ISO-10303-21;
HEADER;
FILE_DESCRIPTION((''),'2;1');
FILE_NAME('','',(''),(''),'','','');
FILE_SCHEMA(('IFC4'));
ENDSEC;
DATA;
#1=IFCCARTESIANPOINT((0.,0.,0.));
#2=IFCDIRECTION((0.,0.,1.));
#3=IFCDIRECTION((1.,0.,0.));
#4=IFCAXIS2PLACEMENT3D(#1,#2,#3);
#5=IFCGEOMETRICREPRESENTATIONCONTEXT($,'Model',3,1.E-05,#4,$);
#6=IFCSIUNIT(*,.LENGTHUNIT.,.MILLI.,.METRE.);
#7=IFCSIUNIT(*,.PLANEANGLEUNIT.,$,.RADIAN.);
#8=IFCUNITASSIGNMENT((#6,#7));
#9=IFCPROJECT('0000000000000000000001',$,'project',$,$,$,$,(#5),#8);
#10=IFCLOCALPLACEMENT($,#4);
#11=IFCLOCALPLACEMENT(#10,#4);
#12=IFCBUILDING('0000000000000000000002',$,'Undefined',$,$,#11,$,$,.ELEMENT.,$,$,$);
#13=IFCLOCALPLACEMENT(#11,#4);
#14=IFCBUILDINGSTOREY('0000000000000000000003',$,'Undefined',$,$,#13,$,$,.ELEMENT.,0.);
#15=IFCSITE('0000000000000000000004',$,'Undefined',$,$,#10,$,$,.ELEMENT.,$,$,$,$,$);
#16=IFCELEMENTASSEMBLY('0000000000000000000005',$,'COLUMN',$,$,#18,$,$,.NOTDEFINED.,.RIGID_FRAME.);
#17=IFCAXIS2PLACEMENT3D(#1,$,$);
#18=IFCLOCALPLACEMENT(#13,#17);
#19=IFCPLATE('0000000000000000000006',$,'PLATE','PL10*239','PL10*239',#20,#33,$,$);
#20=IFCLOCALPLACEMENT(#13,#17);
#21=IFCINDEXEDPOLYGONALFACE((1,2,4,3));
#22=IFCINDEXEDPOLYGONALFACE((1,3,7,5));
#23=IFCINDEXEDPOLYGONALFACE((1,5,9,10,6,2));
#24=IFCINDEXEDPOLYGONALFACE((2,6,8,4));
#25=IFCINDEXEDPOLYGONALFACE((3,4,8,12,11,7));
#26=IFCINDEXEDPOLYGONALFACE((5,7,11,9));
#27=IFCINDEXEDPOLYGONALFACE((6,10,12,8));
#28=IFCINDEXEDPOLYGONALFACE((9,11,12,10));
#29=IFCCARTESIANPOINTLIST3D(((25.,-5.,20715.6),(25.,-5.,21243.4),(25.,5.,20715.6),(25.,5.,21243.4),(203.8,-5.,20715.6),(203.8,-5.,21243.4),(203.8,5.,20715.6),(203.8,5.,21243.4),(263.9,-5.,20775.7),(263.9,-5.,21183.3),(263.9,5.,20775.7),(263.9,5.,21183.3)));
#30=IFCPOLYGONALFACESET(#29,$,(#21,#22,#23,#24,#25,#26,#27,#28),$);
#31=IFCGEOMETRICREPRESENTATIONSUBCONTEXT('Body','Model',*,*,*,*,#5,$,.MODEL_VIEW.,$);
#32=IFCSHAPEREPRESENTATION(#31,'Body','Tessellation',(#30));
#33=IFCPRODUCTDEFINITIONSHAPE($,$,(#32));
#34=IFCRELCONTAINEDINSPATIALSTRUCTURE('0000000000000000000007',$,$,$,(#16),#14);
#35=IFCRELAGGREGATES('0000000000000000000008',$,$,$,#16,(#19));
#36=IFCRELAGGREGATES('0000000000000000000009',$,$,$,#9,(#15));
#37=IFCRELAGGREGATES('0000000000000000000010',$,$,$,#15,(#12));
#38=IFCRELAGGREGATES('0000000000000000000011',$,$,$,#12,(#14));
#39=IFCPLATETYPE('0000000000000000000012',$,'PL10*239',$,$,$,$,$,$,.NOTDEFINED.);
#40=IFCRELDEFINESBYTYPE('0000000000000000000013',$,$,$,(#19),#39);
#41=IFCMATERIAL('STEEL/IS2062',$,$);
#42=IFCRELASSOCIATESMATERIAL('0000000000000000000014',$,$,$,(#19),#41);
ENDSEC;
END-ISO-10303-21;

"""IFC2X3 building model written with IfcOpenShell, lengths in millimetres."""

from ifc_helpers import new_model, si_unit, frame, origin_with_axes, place, context, subcontext, project, spatial, polyline, outline, extrude, material, type_object, element, aggregate, save


model = new_model("IFC2X3")

# Units and contexts
model_context = context("Model", 3, precision=1e-05, world=origin_with_axes())
body_context = subcontext(model_context, "Body", "Model", "MODEL_VIEW")
ifc_project = project(units=[si_unit("LENGTHUNIT", "METRE", prefix="MILLI"), si_unit("PLANEANGLEUNIT", "RADIAN")], contexts=[model_context])

# Site, building, storey
site_placement = place(None, origin_with_axes())
site = spatial("IfcSite", under=ifc_project, at=site_placement, Name="Undefined", CompositionType="ELEMENT")
building_placement = place(site_placement, origin_with_axes())
building = spatial("IfcBuilding", under=site, at=building_placement, Name="Undefined", CompositionType="ELEMENT")
storey_placement = place(building_placement, origin_with_axes())
storey = spatial("IfcBuildingStorey", under=building, at=storey_placement, Name="Undefined", CompositionType="ELEMENT", Elevation=0.0)

# Shared definitions
ifc_material = material(Name="STEEL/IS2062")

# Shared definitions
plate_type_1 = type_object("IfcPlateType", Name="PL10*239", PredefinedType="NOTDEFINED")

# Element assembly, plate
assembly_1_placement = place(storey_placement, origin_with_axes())
assembly_1 = element("IfcElementAssembly", 1, at=assembly_1_placement, inside=storey, Name="COLUMN", AssemblyPlace="NOTDEFINED", PredefinedType="RIGID_FRAME")
plate_1_placement = place(assembly_1_placement, frame((25.0, 0.0, 20715.6), z_axis=(0.0, 1.0, 0.0), x_axis=(0.0, 0.0, 1.0)))
plate_1 = element("IfcPlate", 2, at=plate_1_placement, type_object=plate_type_1, material=ifc_material, Name="PLATE", Description="PL10*239", ObjectType="PL10*239", context=body_context, shape_type="SweptSolid", body=[
    extrude(outline(polyline([(0.0, 0.0), (527.8, 0.0), (527.8, 178.8), (467.7, 238.9), (60.1, 238.9), (0.0, 178.8), (0.0, 0.0)])), frame((0.0, 0.0, -5.0), z_axis=(0.0, 0.0, 1.0), x_axis=(1.0, 0.0, 0.0)), (0.0, 0.0, 1.0), 10.0),
])
aggregate(assembly_1, [plate_1])

save(model, "model.ifc")
